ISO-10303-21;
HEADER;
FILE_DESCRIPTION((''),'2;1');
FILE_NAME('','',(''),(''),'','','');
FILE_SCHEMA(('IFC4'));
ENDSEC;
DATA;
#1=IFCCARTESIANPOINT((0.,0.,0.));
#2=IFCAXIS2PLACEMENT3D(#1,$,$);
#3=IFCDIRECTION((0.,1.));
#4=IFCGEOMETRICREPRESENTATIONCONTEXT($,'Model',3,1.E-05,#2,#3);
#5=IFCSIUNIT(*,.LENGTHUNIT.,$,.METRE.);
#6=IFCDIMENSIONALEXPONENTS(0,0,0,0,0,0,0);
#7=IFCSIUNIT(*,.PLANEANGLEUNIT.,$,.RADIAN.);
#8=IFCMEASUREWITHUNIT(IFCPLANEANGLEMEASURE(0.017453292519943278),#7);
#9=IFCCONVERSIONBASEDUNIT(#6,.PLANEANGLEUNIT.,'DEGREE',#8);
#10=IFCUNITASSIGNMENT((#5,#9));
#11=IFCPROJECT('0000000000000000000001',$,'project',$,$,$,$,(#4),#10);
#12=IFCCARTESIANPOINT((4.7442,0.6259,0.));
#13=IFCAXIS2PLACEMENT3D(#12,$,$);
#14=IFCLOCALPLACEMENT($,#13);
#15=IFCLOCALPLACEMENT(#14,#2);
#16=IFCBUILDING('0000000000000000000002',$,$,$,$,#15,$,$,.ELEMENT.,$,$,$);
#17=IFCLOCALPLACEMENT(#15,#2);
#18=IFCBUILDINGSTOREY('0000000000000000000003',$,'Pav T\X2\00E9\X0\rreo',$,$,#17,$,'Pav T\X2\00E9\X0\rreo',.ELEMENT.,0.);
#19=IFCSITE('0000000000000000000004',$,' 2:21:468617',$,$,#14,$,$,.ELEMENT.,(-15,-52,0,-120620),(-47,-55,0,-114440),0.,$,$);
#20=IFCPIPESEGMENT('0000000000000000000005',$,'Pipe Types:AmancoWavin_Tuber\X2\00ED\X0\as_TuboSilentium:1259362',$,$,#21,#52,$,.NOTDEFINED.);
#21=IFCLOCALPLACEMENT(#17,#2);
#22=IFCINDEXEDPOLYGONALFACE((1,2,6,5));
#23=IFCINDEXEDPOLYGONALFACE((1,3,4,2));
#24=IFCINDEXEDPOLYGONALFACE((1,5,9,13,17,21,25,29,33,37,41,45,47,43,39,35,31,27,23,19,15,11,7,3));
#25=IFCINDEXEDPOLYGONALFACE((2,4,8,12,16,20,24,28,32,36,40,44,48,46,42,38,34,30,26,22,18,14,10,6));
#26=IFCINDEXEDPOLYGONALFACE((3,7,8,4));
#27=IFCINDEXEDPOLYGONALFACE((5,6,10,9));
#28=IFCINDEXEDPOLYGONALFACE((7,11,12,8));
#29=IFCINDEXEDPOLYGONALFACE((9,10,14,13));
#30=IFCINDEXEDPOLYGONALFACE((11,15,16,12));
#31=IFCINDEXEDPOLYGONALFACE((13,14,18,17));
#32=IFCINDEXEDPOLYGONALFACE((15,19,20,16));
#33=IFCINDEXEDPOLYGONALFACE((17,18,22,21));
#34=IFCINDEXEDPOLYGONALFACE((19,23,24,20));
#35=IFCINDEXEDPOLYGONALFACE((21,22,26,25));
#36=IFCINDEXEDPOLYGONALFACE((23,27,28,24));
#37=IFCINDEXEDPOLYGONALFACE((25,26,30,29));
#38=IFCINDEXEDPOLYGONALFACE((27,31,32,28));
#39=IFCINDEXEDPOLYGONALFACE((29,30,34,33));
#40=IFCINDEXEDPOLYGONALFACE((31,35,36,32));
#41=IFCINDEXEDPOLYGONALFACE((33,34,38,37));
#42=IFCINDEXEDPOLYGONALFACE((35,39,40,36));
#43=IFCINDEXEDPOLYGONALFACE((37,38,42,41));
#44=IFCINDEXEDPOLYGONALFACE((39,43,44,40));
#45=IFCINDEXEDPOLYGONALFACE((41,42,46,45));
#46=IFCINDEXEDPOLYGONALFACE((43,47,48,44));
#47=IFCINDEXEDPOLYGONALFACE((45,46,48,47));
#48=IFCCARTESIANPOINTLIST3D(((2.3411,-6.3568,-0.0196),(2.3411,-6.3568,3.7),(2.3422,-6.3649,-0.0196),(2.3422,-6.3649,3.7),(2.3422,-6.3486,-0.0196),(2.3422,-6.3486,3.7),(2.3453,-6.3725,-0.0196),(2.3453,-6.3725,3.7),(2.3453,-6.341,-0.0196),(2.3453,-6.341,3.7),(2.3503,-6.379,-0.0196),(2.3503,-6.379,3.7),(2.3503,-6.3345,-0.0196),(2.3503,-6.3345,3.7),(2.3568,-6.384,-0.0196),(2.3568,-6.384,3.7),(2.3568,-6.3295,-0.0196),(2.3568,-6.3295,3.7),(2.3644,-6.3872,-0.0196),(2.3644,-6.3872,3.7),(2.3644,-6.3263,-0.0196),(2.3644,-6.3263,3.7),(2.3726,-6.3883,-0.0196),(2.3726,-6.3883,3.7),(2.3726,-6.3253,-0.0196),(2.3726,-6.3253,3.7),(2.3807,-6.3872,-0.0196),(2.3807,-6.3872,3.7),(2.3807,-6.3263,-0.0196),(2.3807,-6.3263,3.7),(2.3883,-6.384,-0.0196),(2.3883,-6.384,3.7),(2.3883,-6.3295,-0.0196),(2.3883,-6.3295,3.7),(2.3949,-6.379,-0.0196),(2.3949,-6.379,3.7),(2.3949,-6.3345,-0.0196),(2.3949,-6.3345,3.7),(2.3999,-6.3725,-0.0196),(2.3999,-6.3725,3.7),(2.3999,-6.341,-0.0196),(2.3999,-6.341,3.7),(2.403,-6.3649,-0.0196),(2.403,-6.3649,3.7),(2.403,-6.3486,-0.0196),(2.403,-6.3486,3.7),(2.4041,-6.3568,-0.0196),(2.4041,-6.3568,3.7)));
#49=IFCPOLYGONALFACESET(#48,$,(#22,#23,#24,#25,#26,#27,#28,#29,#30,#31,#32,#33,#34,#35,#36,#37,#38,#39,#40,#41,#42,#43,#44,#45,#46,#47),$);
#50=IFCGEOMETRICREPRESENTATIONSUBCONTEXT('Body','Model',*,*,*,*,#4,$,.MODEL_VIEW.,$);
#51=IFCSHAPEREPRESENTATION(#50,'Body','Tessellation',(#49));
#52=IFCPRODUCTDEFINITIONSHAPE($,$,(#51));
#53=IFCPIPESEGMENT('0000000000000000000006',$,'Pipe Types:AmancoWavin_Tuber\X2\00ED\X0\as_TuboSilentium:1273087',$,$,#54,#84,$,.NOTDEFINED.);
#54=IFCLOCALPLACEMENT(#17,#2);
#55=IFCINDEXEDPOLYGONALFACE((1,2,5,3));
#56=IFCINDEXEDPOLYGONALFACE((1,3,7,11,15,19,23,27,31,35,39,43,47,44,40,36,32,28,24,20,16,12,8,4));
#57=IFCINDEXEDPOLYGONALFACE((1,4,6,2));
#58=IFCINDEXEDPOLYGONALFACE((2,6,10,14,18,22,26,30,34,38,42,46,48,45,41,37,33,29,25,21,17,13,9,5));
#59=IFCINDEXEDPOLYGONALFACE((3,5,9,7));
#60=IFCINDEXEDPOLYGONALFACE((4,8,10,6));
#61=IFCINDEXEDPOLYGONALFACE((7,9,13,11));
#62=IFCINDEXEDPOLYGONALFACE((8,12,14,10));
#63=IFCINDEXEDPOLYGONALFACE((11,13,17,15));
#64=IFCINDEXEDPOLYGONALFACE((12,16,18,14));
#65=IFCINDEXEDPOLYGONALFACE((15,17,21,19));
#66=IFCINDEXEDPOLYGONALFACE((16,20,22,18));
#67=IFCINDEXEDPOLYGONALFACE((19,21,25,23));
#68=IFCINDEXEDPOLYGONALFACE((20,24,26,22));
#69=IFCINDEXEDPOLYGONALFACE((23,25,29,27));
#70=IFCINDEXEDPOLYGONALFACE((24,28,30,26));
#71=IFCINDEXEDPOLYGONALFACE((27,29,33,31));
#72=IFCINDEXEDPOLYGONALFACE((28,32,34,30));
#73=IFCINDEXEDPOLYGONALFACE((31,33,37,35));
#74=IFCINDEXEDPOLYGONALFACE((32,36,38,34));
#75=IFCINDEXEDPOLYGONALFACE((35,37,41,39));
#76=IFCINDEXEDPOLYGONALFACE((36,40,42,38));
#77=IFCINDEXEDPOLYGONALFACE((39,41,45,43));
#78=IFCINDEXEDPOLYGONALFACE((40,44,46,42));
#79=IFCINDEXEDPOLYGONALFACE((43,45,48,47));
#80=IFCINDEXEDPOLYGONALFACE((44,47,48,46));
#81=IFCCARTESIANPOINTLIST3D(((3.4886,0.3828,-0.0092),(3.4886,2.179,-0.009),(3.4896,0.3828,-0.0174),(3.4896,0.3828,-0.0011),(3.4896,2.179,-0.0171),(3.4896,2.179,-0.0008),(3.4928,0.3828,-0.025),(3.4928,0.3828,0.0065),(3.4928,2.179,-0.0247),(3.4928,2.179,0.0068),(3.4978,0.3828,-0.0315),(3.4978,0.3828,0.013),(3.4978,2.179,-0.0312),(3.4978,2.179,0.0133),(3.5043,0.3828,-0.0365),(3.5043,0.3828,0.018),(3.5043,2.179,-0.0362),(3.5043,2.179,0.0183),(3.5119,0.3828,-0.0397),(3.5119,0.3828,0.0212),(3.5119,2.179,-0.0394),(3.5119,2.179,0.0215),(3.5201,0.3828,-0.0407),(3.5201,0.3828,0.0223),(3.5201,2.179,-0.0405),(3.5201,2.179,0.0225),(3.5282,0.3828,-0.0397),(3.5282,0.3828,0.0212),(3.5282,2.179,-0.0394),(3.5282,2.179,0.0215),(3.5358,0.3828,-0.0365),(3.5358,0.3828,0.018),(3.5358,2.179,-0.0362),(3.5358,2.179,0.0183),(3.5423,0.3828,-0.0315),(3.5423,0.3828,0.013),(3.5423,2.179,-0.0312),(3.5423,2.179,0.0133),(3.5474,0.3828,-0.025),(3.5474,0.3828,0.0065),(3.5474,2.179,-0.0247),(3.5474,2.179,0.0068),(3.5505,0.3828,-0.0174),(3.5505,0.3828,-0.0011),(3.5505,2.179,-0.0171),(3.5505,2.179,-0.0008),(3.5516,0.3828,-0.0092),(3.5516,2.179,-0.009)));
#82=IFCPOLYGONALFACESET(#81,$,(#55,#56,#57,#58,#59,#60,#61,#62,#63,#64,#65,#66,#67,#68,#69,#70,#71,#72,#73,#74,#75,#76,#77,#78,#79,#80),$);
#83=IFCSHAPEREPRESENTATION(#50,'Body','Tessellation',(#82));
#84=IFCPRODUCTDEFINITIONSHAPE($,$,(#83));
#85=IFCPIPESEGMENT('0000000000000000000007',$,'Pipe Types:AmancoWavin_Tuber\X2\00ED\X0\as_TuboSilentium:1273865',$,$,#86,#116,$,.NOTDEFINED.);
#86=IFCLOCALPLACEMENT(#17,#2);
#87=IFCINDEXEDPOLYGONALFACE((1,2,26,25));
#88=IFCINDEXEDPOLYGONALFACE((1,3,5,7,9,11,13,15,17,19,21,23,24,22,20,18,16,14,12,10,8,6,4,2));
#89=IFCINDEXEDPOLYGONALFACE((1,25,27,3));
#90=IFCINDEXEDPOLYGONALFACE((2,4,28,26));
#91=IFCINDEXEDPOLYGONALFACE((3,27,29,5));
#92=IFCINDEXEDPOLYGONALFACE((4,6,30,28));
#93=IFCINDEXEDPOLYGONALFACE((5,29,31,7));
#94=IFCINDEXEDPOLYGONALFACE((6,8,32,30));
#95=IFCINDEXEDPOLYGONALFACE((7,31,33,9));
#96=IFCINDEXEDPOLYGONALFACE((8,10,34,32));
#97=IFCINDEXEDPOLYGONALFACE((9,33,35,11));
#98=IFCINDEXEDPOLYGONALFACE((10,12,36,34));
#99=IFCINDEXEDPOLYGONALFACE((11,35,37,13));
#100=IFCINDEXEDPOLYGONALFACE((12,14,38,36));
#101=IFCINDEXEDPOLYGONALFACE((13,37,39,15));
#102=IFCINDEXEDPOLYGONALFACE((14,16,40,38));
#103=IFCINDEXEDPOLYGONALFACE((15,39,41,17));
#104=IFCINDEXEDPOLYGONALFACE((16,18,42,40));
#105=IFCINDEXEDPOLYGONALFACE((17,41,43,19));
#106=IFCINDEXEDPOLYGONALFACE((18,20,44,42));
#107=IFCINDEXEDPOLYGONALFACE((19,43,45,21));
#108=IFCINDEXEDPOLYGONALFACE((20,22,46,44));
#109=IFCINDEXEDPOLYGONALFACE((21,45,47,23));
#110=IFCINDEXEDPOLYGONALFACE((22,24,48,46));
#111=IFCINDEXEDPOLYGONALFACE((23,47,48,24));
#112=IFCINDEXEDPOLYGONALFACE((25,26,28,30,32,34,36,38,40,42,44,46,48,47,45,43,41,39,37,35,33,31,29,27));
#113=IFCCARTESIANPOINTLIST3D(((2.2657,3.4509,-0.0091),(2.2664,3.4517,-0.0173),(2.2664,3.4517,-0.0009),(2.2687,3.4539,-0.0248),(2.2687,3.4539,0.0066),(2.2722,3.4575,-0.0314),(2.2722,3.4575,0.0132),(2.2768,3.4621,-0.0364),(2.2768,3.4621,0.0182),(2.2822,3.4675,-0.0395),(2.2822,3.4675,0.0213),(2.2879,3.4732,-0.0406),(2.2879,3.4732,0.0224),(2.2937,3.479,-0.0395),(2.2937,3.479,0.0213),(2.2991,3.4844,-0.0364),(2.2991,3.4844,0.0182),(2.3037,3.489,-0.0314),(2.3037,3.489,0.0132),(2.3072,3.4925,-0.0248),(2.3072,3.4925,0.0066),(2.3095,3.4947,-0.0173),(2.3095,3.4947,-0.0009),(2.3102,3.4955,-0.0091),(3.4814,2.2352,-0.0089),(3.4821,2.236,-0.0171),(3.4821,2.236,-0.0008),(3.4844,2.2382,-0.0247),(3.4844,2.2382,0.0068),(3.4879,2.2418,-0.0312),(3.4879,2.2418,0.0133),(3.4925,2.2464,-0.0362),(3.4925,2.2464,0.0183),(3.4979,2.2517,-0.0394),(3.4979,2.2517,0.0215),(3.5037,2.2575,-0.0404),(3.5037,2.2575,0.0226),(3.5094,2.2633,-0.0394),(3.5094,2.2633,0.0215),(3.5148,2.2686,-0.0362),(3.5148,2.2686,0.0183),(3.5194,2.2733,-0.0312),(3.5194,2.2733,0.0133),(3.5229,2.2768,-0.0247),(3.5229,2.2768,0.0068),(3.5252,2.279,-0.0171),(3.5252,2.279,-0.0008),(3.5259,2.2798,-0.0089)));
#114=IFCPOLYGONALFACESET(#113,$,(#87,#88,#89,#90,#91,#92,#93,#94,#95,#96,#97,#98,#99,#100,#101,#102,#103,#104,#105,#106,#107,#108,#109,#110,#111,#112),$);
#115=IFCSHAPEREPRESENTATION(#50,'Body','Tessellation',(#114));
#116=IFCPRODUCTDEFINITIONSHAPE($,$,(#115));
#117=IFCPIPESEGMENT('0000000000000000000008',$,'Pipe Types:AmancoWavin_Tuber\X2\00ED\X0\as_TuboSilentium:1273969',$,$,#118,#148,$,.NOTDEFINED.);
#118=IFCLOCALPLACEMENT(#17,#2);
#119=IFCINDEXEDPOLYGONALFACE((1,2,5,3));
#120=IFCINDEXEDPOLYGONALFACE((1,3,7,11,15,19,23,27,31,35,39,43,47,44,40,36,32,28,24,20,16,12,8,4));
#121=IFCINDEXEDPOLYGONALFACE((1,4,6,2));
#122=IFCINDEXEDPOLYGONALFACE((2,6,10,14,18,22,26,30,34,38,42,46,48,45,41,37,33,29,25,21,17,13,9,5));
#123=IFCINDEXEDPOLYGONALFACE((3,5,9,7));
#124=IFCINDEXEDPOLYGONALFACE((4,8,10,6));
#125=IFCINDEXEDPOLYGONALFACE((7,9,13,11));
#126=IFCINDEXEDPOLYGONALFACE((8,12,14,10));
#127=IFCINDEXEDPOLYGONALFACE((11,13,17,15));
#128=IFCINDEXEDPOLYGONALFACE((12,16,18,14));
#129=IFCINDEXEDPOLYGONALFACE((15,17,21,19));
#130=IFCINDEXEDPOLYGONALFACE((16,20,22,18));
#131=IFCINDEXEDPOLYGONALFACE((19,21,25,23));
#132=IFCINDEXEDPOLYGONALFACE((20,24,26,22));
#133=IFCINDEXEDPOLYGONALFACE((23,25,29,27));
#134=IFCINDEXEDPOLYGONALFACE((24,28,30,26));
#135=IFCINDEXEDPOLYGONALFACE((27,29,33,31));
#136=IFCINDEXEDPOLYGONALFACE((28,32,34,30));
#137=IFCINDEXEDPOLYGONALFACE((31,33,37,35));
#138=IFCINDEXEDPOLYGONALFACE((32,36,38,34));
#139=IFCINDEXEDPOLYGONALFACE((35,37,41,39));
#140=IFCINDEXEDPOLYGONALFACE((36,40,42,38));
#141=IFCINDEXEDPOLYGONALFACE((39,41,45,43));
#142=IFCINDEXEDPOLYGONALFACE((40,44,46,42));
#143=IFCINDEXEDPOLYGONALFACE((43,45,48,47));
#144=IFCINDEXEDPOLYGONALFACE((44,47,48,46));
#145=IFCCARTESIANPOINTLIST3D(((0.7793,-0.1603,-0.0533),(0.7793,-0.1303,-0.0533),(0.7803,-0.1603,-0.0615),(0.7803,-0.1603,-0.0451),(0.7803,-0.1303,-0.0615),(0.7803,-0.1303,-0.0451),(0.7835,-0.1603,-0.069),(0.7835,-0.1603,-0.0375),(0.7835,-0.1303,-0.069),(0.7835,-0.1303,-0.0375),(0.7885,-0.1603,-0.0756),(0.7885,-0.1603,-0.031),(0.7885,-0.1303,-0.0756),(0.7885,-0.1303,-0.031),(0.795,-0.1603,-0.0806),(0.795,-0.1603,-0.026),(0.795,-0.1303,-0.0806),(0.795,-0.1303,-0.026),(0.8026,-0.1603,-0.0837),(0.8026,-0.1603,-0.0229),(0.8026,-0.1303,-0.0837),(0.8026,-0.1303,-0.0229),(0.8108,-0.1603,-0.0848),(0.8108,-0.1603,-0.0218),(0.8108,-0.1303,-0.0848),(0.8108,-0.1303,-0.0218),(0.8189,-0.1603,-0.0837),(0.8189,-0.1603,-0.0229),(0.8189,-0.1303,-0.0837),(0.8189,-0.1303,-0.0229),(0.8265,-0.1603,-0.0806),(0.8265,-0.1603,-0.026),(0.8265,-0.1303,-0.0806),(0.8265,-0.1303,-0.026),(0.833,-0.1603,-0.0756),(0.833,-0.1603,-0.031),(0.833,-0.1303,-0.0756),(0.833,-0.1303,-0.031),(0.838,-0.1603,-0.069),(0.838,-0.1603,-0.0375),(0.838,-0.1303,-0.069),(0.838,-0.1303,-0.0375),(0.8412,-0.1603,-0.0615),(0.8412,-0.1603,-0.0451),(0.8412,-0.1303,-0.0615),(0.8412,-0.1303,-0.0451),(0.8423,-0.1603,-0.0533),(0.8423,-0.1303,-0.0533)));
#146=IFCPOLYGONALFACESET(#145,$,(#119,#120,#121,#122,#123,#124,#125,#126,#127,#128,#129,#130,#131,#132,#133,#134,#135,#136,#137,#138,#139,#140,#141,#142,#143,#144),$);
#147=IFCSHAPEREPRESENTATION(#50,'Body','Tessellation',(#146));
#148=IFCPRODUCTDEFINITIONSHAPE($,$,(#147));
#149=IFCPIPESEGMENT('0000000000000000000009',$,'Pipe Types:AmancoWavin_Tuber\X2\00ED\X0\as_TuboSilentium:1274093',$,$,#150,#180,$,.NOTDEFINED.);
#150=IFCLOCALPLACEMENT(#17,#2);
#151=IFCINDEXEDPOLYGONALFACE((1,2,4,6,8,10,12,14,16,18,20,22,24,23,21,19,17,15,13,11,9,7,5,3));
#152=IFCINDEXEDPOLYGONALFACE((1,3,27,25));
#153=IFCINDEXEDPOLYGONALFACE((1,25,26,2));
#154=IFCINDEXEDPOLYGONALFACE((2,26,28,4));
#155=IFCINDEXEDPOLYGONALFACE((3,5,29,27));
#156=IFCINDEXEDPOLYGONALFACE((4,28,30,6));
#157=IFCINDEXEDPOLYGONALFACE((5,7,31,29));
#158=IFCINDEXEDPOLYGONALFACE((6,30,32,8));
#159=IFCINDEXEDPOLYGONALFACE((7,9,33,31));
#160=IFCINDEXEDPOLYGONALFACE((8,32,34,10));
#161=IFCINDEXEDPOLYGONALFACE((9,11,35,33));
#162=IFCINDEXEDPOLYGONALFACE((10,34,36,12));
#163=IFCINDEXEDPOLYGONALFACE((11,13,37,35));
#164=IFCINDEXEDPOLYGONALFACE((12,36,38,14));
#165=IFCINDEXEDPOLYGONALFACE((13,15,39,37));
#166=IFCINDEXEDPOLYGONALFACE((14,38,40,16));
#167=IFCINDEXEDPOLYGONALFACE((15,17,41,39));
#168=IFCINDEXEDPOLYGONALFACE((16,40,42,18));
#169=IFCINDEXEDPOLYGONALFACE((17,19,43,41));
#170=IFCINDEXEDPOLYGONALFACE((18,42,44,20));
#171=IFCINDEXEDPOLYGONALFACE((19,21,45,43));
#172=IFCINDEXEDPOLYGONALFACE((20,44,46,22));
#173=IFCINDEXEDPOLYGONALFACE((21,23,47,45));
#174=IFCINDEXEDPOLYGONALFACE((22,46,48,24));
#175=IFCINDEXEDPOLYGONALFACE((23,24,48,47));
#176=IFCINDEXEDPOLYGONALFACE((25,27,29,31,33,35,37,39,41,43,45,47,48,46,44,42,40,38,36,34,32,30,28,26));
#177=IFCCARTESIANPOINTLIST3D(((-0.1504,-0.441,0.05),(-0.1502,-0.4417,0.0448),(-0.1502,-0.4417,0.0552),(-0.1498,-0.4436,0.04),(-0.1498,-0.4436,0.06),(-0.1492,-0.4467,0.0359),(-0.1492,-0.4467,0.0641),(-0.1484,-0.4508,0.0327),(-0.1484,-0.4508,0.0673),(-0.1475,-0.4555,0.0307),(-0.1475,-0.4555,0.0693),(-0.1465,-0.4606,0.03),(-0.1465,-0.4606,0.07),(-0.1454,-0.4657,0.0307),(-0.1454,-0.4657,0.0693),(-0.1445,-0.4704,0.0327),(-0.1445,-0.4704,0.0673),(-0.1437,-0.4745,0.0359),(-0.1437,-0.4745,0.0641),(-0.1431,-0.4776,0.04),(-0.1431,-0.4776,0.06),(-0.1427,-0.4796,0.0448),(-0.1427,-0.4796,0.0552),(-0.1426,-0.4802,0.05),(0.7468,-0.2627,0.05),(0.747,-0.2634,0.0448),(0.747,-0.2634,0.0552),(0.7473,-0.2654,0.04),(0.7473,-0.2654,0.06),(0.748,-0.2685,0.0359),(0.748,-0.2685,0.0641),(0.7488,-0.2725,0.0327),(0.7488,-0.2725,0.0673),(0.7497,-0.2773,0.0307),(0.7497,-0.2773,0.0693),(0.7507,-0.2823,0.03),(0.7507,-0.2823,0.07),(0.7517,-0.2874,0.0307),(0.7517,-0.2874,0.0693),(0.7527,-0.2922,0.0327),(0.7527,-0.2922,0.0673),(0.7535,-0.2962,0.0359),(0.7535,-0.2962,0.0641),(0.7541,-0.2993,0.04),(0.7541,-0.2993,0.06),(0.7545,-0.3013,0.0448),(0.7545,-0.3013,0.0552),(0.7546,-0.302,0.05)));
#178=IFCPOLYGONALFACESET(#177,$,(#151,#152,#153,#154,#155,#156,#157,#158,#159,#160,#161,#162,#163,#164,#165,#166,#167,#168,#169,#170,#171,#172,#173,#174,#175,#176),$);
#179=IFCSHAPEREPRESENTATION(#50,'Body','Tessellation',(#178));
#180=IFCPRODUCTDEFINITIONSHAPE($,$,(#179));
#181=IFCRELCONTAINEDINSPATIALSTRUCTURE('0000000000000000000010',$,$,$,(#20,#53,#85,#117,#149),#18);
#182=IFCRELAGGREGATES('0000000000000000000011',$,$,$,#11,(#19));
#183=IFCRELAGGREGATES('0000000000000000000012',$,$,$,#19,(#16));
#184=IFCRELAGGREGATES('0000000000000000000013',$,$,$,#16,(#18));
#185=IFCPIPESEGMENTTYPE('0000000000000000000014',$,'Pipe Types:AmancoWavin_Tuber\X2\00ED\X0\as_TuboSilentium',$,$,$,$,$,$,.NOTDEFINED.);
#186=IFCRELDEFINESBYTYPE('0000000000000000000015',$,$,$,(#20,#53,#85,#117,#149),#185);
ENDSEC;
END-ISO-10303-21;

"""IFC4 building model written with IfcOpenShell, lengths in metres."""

from ifc_helpers import new_model, entity, si_unit, converted_unit, direction, frame, origin, place, context, subcontext, project, spatial, arc, indexed_curve, outline, extrude, type_object, element, save


model = new_model("IFC4")

# Units and contexts
model_context = context("Model", 3, precision=1e-05, world=origin(), true_north=direction((0.0, 1.0)))
body_context = subcontext(model_context, "Body", "Model", "MODEL_VIEW")
ifc_project = project(units=[si_unit("LENGTHUNIT", "METRE"), converted_unit("PLANEANGLEUNIT", "DEGREE", entity("IfcPlaneAngleMeasure", 0.017453292519943278), si_unit("PLANEANGLEUNIT", "RADIAN"), dimensions=[0, 0, 0, 0, 0, 0, 0])], contexts=[model_context])

# Site, building, storey
site_placement = place(None, frame((4.7442, 0.6259, 0.0)))
site = spatial("IfcSite", under=ifc_project, at=site_placement, Name=" 2:21:468617", CompositionType="ELEMENT", RefLatitude=(-15, -52, 0, -120620), RefLongitude=(-47, -55, 0, -114440), RefElevation=0.0)
building_placement = place(site_placement, origin())
building = spatial("IfcBuilding", under=site, at=building_placement, CompositionType="ELEMENT")
storey_placement = place(building_placement, origin())
storey = spatial("IfcBuildingStorey", under=building, at=storey_placement, Name="Pav Térreo", LongName="Pav Térreo", CompositionType="ELEMENT", Elevation=0.0)

# Pipe segments
pipe_segment_type_1 = type_object("IfcPipeSegmentType", Name="Pipe Types:AmancoWavin_Tuberías_TuboSilentium", PredefinedType="NOTDEFINED")
pipe_segment_1_placement = place(storey_placement, origin())
element("IfcPipeSegment", 1, at=pipe_segment_1_placement, inside=storey, type_object=pipe_segment_type_1, Name="Pipe Types:AmancoWavin_Tuberías_TuboSilentium:1259362", PredefinedType="NOTDEFINED", context=body_context, shape_type="SweptSolid", body=[
    extrude(outline(indexed_curve([(0.0315, 0.0), (0.0223, 0.0223), (0.0, 0.0315), (-0.0223, 0.0223), (-0.0315, 0.0), (-0.0223, -0.0223), (0.0, -0.0315), (0.0223, -0.0223)], segments=[arc(1, 2, 3), arc(3, 4, 5), arc(5, 6, 7), arc(7, 8, 1)], self_intersect=False)), frame((2.3726, -6.3568, -0.0196), z_axis=(0.0, 0.0, 1.0), x_axis=(-1.0, 0.0, 0.0)), (0.0, 0.0, 1.0), 3.7196),
])
pipe_segment_2_placement = place(storey_placement, origin())
element("IfcPipeSegment", 2, at=pipe_segment_2_placement, inside=storey, type_object=pipe_segment_type_1, Name="Pipe Types:AmancoWavin_Tuberías_TuboSilentium:1273087", PredefinedType="NOTDEFINED", context=body_context, shape_type="SweptSolid", body=[
    extrude(outline(indexed_curve([(0.0315, 0.0), (0.0223, 0.0223), (0.0, 0.0315), (-0.0223, 0.0223), (-0.0315, 0.0), (-0.0223, -0.0223), (0.0, -0.0315), (0.0223, -0.0223)], segments=[arc(1, 2, 3), arc(3, 4, 5), arc(5, 6, 7), arc(7, 8, 1)], self_intersect=False)), frame((3.5201, 0.3828, -0.0092), z_axis=(0.0, 1.0, 0.000161), x_axis=(-1.0, 0.0, 0.0)), (0.0, 0.0, 1.0), 1.7962),
])
pipe_segment_3_placement = place(storey_placement, origin())
element("IfcPipeSegment", 3, at=pipe_segment_3_placement, inside=storey, type_object=pipe_segment_type_1, Name="Pipe Types:AmancoWavin_Tuberías_TuboSilentium:1273865", PredefinedType="NOTDEFINED", context=body_context, shape_type="SweptSolid", body=[
    extrude(outline(indexed_curve([(0.0315, 0.0), (0.0223, 0.0223), (0.0, 0.0315), (-0.0223, 0.0223), (-0.0315, 0.0), (-0.0223, -0.0223), (0.0, -0.0315), (0.0223, -0.0223)], segments=[arc(1, 2, 3), arc(3, 4, 5), arc(5, 6, 7), arc(7, 8, 1)], self_intersect=False)), frame((3.5037, 2.2575, -0.0089), z_axis=(-0.707107, 0.707107, -0.00009), x_axis=(0.707107, 0.707107, 0.0)), (0.0, 0.0, 1.0), 1.7193),
])
pipe_segment_4_placement = place(storey_placement, origin())
element("IfcPipeSegment", 4, at=pipe_segment_4_placement, inside=storey, type_object=pipe_segment_type_1, Name="Pipe Types:AmancoWavin_Tuberías_TuboSilentium:1273969", PredefinedType="NOTDEFINED", context=body_context, shape_type="SweptSolid", body=[
    extrude(outline(indexed_curve([(0.0315, 0.0), (0.0223, 0.0223), (0.0, 0.0315), (-0.0223, 0.0223), (-0.0315, 0.0), (-0.0223, -0.0223), (0.0, -0.0315), (0.0223, -0.0223)], segments=[arc(1, 2, 3), arc(3, 4, 5), arc(5, 6, 7), arc(7, 8, 1)], self_intersect=False)), frame((0.8108, -0.1603, -0.0533), z_axis=(0.0, 1.0, 0.0), x_axis=(1.0, 0.0, 0.0)), (0.0, 0.0, 1.0), 0.03),
])
pipe_segment_5_placement = place(storey_placement, origin())
element("IfcPipeSegment", 5, at=pipe_segment_5_placement, inside=storey, type_object=pipe_segment_type_1, Name="Pipe Types:AmancoWavin_Tuberías_TuboSilentium:1274093", PredefinedType="NOTDEFINED", context=body_context, shape_type="SweptSolid", body=[
    extrude(outline(indexed_curve([(0.02, 0.0), (0.0141, 0.0141), (0.0, 0.02), (-0.0141, 0.0141), (-0.02, 0.0), (-0.0141, -0.0141), (0.0, -0.02), (0.0141, -0.0141)], segments=[arc(1, 2, 3), arc(3, 4, 5), arc(5, 6, 7), arc(7, 8, 1)], self_intersect=False)), frame((-0.1465, -0.4606, 0.05), z_axis=(0.980826, 0.194885, 0.0), x_axis=(0.194885, -0.980826, 0.0)), (0.0, 0.0, 1.0), 0.9147),
])

save(model, "model.ifc")
